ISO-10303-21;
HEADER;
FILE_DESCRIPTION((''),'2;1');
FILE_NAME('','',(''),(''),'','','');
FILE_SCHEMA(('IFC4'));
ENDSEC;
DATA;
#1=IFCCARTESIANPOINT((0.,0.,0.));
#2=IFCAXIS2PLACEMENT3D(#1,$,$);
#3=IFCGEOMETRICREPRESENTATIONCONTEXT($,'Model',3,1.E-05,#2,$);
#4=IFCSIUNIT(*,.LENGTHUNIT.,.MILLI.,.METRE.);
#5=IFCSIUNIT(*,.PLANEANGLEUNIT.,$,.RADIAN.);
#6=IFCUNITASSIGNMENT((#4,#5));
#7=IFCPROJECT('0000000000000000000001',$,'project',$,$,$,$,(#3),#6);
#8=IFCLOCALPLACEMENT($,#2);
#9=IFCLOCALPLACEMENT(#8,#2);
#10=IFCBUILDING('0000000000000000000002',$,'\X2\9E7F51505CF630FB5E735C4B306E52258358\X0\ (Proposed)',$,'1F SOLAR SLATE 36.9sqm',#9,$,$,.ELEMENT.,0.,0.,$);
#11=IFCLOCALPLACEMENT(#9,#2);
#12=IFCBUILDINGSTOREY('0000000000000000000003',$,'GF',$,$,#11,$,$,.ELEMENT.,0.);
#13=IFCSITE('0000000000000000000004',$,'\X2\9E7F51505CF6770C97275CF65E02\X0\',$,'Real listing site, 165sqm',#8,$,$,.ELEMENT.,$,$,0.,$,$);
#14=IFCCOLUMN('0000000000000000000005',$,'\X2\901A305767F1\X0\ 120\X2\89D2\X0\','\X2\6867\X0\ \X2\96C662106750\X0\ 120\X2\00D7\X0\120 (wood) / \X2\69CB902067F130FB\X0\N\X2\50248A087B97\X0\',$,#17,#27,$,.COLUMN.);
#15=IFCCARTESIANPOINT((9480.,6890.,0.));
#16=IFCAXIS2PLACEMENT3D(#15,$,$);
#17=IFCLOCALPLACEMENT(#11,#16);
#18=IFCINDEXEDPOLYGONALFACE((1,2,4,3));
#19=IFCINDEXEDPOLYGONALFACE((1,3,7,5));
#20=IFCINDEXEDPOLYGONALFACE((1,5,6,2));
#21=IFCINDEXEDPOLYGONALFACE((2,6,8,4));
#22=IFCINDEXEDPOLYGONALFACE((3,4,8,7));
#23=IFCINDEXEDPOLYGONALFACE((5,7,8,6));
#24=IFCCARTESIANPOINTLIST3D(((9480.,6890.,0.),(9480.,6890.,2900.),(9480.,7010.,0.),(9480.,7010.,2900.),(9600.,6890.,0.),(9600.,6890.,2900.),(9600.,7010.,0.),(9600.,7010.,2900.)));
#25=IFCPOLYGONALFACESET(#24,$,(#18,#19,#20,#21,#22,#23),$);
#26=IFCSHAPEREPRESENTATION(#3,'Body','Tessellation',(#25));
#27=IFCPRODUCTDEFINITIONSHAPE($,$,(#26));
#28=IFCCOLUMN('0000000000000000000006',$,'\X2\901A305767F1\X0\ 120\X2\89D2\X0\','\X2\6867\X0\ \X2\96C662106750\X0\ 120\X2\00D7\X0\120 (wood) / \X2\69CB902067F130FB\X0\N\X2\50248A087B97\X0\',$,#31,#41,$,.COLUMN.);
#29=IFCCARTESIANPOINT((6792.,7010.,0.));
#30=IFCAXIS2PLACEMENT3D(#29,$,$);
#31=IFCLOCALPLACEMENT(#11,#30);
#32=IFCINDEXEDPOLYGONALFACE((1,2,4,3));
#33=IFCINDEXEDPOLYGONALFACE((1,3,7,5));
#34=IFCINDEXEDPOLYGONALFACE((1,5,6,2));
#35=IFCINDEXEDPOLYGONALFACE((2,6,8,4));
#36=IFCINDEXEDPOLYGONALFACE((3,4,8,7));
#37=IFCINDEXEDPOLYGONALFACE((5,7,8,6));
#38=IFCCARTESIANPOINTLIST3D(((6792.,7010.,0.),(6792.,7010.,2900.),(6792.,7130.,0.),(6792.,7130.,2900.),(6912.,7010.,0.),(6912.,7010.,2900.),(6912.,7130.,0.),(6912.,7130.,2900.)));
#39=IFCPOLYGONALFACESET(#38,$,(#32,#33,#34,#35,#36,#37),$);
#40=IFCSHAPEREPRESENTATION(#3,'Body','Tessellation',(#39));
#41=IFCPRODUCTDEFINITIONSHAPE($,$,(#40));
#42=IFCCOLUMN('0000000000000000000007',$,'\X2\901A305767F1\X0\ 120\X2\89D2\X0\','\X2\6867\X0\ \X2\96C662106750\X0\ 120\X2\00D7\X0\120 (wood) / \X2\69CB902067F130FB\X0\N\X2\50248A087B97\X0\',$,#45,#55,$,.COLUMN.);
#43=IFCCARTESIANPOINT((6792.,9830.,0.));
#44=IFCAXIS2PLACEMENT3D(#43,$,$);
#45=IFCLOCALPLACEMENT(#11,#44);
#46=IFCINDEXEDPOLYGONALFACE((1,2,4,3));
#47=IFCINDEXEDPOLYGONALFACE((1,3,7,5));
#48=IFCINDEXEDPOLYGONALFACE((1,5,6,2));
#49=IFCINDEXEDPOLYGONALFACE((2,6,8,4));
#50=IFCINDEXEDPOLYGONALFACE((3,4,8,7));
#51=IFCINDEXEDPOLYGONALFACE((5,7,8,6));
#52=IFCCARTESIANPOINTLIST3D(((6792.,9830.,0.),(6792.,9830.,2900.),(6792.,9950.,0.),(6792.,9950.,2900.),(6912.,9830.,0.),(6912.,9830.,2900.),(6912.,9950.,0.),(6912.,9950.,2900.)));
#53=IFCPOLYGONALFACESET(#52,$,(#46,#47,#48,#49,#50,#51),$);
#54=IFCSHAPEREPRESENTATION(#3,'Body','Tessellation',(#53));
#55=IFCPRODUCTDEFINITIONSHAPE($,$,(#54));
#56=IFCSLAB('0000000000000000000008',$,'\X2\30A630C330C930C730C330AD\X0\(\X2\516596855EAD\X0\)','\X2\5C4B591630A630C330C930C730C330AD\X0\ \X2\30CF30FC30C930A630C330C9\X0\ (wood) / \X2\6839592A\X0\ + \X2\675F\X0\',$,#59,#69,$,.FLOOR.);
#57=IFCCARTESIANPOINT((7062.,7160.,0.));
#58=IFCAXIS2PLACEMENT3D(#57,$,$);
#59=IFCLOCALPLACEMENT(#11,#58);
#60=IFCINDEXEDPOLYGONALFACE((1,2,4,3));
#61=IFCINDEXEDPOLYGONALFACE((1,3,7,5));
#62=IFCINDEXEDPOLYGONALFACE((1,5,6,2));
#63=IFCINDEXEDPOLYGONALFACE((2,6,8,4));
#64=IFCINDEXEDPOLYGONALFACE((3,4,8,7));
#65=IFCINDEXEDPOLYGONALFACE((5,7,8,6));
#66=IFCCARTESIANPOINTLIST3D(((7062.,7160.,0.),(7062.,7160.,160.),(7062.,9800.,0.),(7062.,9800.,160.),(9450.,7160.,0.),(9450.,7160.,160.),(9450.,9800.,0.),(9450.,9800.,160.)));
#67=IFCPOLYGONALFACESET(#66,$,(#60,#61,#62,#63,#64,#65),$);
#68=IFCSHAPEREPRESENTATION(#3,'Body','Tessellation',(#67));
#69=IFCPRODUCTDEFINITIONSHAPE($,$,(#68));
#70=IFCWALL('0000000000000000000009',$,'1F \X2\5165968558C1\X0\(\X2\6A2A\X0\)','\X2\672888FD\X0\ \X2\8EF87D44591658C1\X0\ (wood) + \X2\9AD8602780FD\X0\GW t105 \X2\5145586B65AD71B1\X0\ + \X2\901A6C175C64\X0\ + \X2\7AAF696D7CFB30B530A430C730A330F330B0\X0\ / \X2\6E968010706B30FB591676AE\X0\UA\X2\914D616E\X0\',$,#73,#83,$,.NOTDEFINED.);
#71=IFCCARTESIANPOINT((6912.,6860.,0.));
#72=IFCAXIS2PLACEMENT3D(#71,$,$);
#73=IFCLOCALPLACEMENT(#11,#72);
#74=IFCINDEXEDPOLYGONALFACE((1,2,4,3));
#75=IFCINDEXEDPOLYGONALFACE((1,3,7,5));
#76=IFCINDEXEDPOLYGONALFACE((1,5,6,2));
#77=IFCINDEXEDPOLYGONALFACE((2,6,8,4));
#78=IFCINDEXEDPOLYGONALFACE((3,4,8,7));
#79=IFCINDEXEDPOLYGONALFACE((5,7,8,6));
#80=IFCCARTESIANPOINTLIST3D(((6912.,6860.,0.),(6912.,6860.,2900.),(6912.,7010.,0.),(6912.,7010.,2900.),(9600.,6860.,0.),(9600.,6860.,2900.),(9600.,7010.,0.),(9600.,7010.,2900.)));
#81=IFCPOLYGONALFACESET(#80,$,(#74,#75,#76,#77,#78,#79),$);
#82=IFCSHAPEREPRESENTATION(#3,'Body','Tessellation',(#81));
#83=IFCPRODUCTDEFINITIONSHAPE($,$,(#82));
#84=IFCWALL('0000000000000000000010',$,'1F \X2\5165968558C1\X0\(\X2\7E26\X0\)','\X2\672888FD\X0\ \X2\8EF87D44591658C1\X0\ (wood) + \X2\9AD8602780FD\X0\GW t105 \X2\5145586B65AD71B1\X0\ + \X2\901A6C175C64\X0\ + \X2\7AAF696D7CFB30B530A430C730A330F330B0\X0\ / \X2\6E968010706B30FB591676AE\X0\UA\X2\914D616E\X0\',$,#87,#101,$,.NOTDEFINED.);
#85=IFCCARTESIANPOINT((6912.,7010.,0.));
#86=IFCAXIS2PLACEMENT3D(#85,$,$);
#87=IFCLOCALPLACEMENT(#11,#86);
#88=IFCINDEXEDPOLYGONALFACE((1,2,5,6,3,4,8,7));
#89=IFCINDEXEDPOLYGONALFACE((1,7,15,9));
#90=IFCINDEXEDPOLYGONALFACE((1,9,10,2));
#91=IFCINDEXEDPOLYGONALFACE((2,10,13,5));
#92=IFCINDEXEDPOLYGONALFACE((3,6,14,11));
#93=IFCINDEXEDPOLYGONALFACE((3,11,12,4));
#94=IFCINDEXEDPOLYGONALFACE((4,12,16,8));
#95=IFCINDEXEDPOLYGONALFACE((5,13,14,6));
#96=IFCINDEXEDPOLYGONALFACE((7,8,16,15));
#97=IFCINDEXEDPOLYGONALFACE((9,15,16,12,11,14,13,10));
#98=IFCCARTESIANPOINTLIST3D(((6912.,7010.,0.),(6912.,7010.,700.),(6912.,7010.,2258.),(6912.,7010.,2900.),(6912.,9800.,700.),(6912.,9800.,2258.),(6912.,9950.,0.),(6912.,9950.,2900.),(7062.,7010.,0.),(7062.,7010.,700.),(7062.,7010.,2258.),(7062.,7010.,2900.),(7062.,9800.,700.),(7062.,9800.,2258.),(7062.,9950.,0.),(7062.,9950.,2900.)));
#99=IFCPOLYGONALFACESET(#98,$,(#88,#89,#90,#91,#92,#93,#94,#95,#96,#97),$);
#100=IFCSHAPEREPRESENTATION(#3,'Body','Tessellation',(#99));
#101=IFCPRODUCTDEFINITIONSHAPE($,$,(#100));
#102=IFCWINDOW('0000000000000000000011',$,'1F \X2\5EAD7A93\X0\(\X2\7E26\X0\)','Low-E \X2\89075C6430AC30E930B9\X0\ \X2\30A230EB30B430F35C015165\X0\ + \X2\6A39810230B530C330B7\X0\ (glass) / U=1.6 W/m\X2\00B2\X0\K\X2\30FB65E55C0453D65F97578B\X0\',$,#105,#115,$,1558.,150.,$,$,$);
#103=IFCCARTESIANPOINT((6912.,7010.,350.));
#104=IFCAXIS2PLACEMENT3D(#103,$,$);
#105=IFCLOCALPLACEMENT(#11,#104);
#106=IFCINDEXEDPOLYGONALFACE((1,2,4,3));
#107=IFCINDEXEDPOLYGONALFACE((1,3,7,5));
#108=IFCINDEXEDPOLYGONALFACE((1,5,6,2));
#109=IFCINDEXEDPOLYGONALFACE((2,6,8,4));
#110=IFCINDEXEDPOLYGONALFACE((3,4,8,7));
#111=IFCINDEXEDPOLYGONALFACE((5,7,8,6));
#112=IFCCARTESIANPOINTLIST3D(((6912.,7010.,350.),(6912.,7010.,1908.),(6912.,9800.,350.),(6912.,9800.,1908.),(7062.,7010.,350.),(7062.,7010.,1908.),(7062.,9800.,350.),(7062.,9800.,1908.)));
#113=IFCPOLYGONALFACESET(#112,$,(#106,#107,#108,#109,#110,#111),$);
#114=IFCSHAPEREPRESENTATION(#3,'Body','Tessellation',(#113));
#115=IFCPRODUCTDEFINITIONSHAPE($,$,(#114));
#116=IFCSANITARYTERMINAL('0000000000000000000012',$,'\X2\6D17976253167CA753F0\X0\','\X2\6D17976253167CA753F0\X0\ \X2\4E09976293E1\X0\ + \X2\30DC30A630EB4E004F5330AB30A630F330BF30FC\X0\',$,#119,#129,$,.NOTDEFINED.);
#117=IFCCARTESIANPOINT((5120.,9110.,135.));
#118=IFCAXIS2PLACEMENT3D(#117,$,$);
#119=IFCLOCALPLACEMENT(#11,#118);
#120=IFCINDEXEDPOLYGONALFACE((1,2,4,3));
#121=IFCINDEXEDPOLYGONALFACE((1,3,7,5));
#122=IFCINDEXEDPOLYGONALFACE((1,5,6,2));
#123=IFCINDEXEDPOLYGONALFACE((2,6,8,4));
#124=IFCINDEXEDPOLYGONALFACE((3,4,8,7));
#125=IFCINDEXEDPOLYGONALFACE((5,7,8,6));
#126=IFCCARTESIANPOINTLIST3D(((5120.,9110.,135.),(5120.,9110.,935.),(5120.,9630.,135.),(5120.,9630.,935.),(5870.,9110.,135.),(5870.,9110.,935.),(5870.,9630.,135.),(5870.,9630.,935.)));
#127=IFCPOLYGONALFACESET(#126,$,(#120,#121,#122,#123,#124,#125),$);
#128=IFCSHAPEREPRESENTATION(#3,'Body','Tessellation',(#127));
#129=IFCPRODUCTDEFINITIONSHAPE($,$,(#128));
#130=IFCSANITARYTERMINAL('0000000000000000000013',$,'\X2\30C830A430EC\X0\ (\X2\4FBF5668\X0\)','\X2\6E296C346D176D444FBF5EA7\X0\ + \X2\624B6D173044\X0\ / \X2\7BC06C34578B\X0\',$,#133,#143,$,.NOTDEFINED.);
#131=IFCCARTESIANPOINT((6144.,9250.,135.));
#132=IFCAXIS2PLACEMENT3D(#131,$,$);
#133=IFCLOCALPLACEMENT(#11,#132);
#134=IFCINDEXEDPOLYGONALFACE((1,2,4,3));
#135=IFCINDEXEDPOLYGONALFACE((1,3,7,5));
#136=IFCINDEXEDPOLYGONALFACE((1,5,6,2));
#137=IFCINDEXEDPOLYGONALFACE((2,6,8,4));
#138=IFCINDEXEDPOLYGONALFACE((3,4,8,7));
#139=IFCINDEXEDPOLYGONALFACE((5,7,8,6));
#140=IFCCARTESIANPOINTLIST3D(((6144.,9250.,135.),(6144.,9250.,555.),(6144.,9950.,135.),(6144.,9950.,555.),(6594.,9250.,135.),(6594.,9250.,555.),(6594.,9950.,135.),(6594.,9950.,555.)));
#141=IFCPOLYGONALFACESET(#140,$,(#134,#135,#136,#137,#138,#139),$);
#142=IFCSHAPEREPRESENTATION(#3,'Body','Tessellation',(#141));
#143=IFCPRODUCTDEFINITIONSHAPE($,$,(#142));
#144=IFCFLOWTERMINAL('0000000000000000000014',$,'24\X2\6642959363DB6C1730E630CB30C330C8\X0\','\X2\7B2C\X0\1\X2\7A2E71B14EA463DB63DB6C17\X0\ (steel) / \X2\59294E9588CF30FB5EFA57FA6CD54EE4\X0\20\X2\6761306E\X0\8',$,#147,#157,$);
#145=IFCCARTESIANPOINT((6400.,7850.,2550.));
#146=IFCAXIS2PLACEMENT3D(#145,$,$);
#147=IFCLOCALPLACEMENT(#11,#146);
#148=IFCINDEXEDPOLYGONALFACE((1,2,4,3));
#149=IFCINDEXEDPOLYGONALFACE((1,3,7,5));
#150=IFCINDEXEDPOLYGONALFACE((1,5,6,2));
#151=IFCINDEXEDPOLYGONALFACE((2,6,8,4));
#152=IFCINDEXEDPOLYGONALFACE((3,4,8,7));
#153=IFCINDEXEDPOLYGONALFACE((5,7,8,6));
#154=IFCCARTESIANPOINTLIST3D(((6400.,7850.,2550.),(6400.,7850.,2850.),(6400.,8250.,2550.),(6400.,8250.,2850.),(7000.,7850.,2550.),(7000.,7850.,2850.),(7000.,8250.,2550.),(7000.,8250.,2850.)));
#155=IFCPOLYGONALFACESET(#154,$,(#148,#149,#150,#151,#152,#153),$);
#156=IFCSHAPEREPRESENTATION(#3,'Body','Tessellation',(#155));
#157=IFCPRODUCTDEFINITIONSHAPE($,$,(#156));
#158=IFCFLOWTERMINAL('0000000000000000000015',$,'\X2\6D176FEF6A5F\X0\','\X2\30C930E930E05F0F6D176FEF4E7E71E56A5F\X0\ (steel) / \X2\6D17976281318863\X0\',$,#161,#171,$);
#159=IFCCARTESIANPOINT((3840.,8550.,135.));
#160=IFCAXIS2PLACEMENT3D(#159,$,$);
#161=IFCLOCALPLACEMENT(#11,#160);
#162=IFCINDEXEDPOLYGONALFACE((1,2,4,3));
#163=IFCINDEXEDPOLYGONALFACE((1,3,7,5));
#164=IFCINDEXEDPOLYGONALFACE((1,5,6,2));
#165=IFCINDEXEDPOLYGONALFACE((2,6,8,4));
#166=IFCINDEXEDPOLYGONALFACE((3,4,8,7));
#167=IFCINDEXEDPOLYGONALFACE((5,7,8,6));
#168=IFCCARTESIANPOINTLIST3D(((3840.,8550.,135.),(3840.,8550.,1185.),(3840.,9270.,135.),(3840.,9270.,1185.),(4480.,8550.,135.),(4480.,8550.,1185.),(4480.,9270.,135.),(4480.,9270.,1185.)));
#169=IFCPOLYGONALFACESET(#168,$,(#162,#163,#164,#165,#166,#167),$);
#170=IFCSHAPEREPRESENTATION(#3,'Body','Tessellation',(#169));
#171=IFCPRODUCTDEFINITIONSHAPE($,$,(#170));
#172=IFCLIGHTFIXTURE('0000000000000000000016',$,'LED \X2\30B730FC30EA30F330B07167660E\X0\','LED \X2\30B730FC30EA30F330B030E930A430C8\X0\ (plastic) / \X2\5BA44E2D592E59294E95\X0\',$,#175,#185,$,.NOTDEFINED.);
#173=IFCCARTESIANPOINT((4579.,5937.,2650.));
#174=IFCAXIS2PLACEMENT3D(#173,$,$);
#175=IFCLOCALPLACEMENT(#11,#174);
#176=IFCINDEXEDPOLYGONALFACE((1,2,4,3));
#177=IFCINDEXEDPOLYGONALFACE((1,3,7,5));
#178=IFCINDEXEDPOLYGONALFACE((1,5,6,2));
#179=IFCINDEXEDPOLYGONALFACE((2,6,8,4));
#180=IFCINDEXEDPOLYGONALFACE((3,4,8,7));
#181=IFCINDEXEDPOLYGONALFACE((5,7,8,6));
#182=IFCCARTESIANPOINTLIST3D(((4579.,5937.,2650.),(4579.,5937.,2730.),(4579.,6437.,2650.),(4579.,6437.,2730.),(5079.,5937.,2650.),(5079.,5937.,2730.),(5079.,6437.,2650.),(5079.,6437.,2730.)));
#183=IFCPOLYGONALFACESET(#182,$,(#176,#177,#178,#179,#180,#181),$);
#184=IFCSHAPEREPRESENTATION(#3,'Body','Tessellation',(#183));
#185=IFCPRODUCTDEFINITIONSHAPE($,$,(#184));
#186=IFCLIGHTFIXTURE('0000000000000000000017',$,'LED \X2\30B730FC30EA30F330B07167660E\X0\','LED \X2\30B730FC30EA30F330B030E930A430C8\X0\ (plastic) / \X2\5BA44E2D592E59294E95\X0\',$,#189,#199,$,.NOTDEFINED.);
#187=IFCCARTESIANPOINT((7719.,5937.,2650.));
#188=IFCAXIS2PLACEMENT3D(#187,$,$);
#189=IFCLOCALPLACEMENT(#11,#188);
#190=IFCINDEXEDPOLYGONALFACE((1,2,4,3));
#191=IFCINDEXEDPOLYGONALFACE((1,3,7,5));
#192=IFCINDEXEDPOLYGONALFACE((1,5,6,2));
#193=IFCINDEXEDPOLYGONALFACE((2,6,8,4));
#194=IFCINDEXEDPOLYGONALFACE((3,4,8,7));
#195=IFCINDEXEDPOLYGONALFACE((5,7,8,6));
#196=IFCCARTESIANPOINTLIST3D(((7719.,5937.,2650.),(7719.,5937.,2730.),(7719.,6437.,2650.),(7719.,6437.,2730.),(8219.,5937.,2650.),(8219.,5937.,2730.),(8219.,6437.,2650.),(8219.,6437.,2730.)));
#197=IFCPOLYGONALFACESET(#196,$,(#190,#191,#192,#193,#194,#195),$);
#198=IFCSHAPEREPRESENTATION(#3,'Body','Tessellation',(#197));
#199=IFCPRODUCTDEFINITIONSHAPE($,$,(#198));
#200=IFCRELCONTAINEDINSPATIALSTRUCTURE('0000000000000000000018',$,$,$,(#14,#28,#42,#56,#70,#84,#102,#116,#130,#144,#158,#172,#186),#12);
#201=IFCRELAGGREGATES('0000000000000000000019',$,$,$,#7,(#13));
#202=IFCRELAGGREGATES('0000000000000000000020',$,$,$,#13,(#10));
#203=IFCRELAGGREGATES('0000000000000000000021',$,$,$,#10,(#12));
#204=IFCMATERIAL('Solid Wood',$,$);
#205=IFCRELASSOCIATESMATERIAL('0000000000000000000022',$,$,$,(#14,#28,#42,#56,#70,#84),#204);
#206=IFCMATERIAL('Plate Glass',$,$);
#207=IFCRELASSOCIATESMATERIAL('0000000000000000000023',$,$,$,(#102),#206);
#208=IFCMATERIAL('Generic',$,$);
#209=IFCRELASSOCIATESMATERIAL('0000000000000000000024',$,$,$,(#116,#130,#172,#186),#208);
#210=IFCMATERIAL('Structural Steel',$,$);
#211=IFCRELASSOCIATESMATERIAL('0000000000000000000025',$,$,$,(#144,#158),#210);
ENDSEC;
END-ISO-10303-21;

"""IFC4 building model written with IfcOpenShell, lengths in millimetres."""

from ifc_helpers import new_model, si_unit, frame, frame_2d, origin, place, context, project, spatial, rectangle, extrude, material, element, fill, save


model = new_model("IFC4")

# Units and contexts
model_context = context("Model", 3, precision=1e-05, world=origin())
ifc_project = project(units=[si_unit("LENGTHUNIT", "METRE", prefix="MILLI"), si_unit("PLANEANGLEUNIT", "RADIAN")], contexts=[model_context])

# Site, building, storey
site_placement = place(None, origin())
site = spatial("IfcSite", under=ifc_project, at=site_placement, Name="鹿児島県霧島市", ObjectType="Real listing site, 165sqm", CompositionType="ELEMENT", RefElevation=0.0)
building_placement = place(site_placement, origin())
building = spatial("IfcBuilding", under=site, at=building_placement, Name="鹿児島・平屋の別荘 (Proposed)", ObjectType="1F SOLAR SLATE 36.9sqm", CompositionType="ELEMENT", ElevationOfRefHeight=0.0, ElevationOfTerrain=0.0)
storey_placement = place(building_placement, origin())
storey = spatial("IfcBuildingStorey", under=building, at=storey_placement, Name="GF", CompositionType="ELEMENT", Elevation=0.0)

# Columns
ifc_material_1 = material(Name="Solid Wood")
column_1_placement = place(storey_placement, frame((9480.0, 6890.0, 0.0)))
element("IfcColumn", 1, at=column_1_placement, inside=storey, material=ifc_material_1, Name="通し柱 120角", Description="桧 集成材 120×120 (wood) / 構造柱・N値計算", PredefinedType="COLUMN", context=model_context, shape_type="SweptSolid", body=[
    extrude(rectangle(XDim=120.0, YDim=120.0, at=frame_2d((60.0, 60.0))), frame((9480.0, 6890.0, 0.0)), (0.0, 0.0, 1.0), 2900.0),
])
column_2_placement = place(storey_placement, frame((6792.0, 7010.0, 0.0)))
element("IfcColumn", 2, at=column_2_placement, inside=storey, material=ifc_material_1, Name="通し柱 120角", Description="桧 集成材 120×120 (wood) / 構造柱・N値計算", PredefinedType="COLUMN", context=model_context, shape_type="SweptSolid", body=[
    extrude(rectangle(XDim=120.0, YDim=120.0, at=frame_2d((60.0, 60.0))), frame((6792.0, 7010.0, 0.0)), (0.0, 0.0, 1.0), 2900.0),
])
column_3_placement = place(storey_placement, frame((6792.0, 9830.0, 0.0)))
element("IfcColumn", 3, at=column_3_placement, inside=storey, material=ifc_material_1, Name="通し柱 120角", Description="桧 集成材 120×120 (wood) / 構造柱・N値計算", PredefinedType="COLUMN", context=model_context, shape_type="SweptSolid", body=[
    extrude(rectangle(XDim=120.0, YDim=120.0, at=frame_2d((60.0, 60.0))), frame((6792.0, 9830.0, 0.0)), (0.0, 0.0, 1.0), 2900.0),
])

# Slab
slab_placement = place(storey_placement, frame((7062.0, 7160.0, 0.0)))
element("IfcSlab", 4, at=slab_placement, inside=storey, material=ifc_material_1, Name="ウッドデッキ(入隅庭)", Description="屋外ウッドデッキ ハードウッド (wood) / 根太 + 束", PredefinedType="FLOOR", context=model_context, shape_type="SweptSolid", body=[
    extrude(rectangle(XDim=2388.0, YDim=2640.0, at=frame_2d((1194.0, 1320.0))), frame((7062.0, 7160.0, 0.0)), (0.0, 0.0, 1.0), 160.0),
])

# Wall
wall_1_placement = place(storey_placement, frame((6912.0, 6860.0, 0.0)))
element("IfcWall", 5, at=wall_1_placement, inside=storey, material=ifc_material_1, Name="1F 入隅壁(横)", Description="木製 軸組外壁 (wood) + 高性能GW t105 充填断熱 + 通気層 + 窯業系サイディング / 準耐火・外皮UA配慮", PredefinedType="NOTDEFINED", context=model_context, shape_type="SweptSolid", body=[
    extrude(rectangle(XDim=2688.0, YDim=150.0, at=frame_2d((1344.0, 75.0))), frame((6912.0, 6860.0, 0.0)), (0.0, 0.0, 1.0), 2900.0),
])

# Wall, opening, window
wall_2_placement = place(storey_placement, frame((6912.0, 7010.0, 0.0)))
wall_2 = element("IfcWall", 6, at=wall_2_placement, inside=storey, material=ifc_material_1, Name="1F 入隅壁(縦)", Description="木製 軸組外壁 (wood) + 高性能GW t105 充填断熱 + 通気層 + 窯業系サイディング / 準耐火・外皮UA配慮", PredefinedType="NOTDEFINED", context=model_context, shape_type="SweptSolid", body=[
    extrude(rectangle(XDim=150.0, YDim=2940.0, at=frame_2d((75.0, 1470.0))), frame((6912.0, 7010.0, 0.0)), (0.0, 0.0, 1.0), 2900.0),
])
opening_placement = place(storey_placement, frame((6912.0, 7010.0, 350.0)))
opening = element("IfcOpeningElement", 7, at=opening_placement, cuts=wall_2, PredefinedType="NOTDEFINED", context=model_context, shape_type="SweptSolid", body=[
    extrude(rectangle(XDim=150.0, YDim=2790.0, at=frame_2d((75.0, 1395.0))), frame((6912.0, 7010.0, 350.0)), (0.0, 0.0, 1.0), 1558.0),
])
ifc_material_2 = material(Name="Plate Glass")
window_placement = place(storey_placement, frame((6912.0, 7010.0, 350.0)))
window = element("IfcWindow", 8, at=window_placement, inside=storey, material=ifc_material_2, Name="1F 庭窓(縦)", Description="Low-E 複層ガラス アルゴン封入 + 樹脂サッシ (glass) / U=1.6 W/m²K・日射取得型", OverallHeight=1558.0, OverallWidth=150.0, context=model_context, shape_type="SweptSolid", body=[
    extrude(rectangle(XDim=150.0, YDim=2790.0, at=frame_2d((75.0, 1395.0))), frame((6912.0, 7010.0, 350.0)), (0.0, 0.0, 1.0), 1558.0),
])
fill(opening, window)

# Sanitary terminals
ifc_material_3 = material(Name="Generic")
sanitary_terminal_1_placement = place(storey_placement, frame((5120.0, 9110.0, 135.0)))
element("IfcSanitaryTerminal", 9, at=sanitary_terminal_1_placement, inside=storey, material=ifc_material_3, Name="洗面化粧台", Description="洗面化粧台 三面鏡 + ボウル一体カウンター", PredefinedType="NOTDEFINED", context=model_context, shape_type="SweptSolid", body=[
    extrude(rectangle(XDim=750.0, YDim=520.0, at=frame_2d((375.0, 260.0))), frame((5120.0, 9110.0, 135.0)), (0.0, 0.0, 1.0), 800.0),
])
sanitary_terminal_2_placement = place(storey_placement, frame((6144.0, 9250.0, 135.0)))
element("IfcSanitaryTerminal", 10, at=sanitary_terminal_2_placement, inside=storey, material=ifc_material_3, Name="トイレ (便器)", Description="温水洗浄便座 + 手洗い / 節水型", PredefinedType="NOTDEFINED", context=model_context, shape_type="SweptSolid", body=[
    extrude(rectangle(XDim=450.0, YDim=700.0, at=frame_2d((225.0, 350.0))), frame((6144.0, 9250.0, 135.0)), (0.0, 0.0, 1.0), 420.0),
])

# Flow terminals
ifc_material_4 = material(Name="Structural Steel")
flow_terminal_1_placement = place(storey_placement, frame((6400.0, 7850.0, 2550.0)))
element("IfcFlowTerminal", 11, at=flow_terminal_1_placement, inside=storey, material=ifc_material_4, Name="24時間換気ユニット", Description="第1種熱交換換気 (steel) / 天井裏・建基法令20条の8", context=model_context, shape_type="SweptSolid", body=[
    extrude(rectangle(XDim=600.0, YDim=400.0, at=frame_2d((300.0, 200.0))), frame((6400.0, 7850.0, 2550.0)), (0.0, 0.0, 1.0), 300.0),
])
flow_terminal_2_placement = place(storey_placement, frame((3840.0, 8550.0, 135.0)))
element("IfcFlowTerminal", 12, at=flow_terminal_2_placement, inside=storey, material=ifc_material_4, Name="洗濯機", Description="ドラム式洗濯乾燥機 (steel) / 洗面脱衣", context=model_context, shape_type="SweptSolid", body=[
    extrude(rectangle(XDim=640.0, YDim=720.0, at=frame_2d((320.0, 360.0))), frame((3840.0, 8550.0, 135.0)), (0.0, 0.0, 1.0), 1050.0),
])

# Light fixtures
light_fixture_1_placement = place(storey_placement, frame((4579.0, 5937.0, 2650.0)))
element("IfcLightFixture", 13, at=light_fixture_1_placement, inside=storey, material=ifc_material_3, Name="LED シーリング照明", Description="LED シーリングライト (plastic) / 室中央天井", PredefinedType="NOTDEFINED", context=model_context, shape_type="SweptSolid", body=[
    extrude(rectangle(XDim=500.0, YDim=500.0, at=frame_2d((250.0, 250.0))), frame((4579.0, 5937.0, 2650.0)), (0.0, 0.0, 1.0), 80.0),
])
light_fixture_2_placement = place(storey_placement, frame((7719.0, 5937.0, 2650.0)))
element("IfcLightFixture", 14, at=light_fixture_2_placement, inside=storey, material=ifc_material_3, Name="LED シーリング照明", Description="LED シーリングライト (plastic) / 室中央天井", PredefinedType="NOTDEFINED", context=model_context, shape_type="SweptSolid", body=[
    extrude(rectangle(XDim=500.0, YDim=500.0, at=frame_2d((250.0, 250.0))), frame((7719.0, 5937.0, 2650.0)), (0.0, 0.0, 1.0), 80.0),
])

save(model, "model.ifc")
